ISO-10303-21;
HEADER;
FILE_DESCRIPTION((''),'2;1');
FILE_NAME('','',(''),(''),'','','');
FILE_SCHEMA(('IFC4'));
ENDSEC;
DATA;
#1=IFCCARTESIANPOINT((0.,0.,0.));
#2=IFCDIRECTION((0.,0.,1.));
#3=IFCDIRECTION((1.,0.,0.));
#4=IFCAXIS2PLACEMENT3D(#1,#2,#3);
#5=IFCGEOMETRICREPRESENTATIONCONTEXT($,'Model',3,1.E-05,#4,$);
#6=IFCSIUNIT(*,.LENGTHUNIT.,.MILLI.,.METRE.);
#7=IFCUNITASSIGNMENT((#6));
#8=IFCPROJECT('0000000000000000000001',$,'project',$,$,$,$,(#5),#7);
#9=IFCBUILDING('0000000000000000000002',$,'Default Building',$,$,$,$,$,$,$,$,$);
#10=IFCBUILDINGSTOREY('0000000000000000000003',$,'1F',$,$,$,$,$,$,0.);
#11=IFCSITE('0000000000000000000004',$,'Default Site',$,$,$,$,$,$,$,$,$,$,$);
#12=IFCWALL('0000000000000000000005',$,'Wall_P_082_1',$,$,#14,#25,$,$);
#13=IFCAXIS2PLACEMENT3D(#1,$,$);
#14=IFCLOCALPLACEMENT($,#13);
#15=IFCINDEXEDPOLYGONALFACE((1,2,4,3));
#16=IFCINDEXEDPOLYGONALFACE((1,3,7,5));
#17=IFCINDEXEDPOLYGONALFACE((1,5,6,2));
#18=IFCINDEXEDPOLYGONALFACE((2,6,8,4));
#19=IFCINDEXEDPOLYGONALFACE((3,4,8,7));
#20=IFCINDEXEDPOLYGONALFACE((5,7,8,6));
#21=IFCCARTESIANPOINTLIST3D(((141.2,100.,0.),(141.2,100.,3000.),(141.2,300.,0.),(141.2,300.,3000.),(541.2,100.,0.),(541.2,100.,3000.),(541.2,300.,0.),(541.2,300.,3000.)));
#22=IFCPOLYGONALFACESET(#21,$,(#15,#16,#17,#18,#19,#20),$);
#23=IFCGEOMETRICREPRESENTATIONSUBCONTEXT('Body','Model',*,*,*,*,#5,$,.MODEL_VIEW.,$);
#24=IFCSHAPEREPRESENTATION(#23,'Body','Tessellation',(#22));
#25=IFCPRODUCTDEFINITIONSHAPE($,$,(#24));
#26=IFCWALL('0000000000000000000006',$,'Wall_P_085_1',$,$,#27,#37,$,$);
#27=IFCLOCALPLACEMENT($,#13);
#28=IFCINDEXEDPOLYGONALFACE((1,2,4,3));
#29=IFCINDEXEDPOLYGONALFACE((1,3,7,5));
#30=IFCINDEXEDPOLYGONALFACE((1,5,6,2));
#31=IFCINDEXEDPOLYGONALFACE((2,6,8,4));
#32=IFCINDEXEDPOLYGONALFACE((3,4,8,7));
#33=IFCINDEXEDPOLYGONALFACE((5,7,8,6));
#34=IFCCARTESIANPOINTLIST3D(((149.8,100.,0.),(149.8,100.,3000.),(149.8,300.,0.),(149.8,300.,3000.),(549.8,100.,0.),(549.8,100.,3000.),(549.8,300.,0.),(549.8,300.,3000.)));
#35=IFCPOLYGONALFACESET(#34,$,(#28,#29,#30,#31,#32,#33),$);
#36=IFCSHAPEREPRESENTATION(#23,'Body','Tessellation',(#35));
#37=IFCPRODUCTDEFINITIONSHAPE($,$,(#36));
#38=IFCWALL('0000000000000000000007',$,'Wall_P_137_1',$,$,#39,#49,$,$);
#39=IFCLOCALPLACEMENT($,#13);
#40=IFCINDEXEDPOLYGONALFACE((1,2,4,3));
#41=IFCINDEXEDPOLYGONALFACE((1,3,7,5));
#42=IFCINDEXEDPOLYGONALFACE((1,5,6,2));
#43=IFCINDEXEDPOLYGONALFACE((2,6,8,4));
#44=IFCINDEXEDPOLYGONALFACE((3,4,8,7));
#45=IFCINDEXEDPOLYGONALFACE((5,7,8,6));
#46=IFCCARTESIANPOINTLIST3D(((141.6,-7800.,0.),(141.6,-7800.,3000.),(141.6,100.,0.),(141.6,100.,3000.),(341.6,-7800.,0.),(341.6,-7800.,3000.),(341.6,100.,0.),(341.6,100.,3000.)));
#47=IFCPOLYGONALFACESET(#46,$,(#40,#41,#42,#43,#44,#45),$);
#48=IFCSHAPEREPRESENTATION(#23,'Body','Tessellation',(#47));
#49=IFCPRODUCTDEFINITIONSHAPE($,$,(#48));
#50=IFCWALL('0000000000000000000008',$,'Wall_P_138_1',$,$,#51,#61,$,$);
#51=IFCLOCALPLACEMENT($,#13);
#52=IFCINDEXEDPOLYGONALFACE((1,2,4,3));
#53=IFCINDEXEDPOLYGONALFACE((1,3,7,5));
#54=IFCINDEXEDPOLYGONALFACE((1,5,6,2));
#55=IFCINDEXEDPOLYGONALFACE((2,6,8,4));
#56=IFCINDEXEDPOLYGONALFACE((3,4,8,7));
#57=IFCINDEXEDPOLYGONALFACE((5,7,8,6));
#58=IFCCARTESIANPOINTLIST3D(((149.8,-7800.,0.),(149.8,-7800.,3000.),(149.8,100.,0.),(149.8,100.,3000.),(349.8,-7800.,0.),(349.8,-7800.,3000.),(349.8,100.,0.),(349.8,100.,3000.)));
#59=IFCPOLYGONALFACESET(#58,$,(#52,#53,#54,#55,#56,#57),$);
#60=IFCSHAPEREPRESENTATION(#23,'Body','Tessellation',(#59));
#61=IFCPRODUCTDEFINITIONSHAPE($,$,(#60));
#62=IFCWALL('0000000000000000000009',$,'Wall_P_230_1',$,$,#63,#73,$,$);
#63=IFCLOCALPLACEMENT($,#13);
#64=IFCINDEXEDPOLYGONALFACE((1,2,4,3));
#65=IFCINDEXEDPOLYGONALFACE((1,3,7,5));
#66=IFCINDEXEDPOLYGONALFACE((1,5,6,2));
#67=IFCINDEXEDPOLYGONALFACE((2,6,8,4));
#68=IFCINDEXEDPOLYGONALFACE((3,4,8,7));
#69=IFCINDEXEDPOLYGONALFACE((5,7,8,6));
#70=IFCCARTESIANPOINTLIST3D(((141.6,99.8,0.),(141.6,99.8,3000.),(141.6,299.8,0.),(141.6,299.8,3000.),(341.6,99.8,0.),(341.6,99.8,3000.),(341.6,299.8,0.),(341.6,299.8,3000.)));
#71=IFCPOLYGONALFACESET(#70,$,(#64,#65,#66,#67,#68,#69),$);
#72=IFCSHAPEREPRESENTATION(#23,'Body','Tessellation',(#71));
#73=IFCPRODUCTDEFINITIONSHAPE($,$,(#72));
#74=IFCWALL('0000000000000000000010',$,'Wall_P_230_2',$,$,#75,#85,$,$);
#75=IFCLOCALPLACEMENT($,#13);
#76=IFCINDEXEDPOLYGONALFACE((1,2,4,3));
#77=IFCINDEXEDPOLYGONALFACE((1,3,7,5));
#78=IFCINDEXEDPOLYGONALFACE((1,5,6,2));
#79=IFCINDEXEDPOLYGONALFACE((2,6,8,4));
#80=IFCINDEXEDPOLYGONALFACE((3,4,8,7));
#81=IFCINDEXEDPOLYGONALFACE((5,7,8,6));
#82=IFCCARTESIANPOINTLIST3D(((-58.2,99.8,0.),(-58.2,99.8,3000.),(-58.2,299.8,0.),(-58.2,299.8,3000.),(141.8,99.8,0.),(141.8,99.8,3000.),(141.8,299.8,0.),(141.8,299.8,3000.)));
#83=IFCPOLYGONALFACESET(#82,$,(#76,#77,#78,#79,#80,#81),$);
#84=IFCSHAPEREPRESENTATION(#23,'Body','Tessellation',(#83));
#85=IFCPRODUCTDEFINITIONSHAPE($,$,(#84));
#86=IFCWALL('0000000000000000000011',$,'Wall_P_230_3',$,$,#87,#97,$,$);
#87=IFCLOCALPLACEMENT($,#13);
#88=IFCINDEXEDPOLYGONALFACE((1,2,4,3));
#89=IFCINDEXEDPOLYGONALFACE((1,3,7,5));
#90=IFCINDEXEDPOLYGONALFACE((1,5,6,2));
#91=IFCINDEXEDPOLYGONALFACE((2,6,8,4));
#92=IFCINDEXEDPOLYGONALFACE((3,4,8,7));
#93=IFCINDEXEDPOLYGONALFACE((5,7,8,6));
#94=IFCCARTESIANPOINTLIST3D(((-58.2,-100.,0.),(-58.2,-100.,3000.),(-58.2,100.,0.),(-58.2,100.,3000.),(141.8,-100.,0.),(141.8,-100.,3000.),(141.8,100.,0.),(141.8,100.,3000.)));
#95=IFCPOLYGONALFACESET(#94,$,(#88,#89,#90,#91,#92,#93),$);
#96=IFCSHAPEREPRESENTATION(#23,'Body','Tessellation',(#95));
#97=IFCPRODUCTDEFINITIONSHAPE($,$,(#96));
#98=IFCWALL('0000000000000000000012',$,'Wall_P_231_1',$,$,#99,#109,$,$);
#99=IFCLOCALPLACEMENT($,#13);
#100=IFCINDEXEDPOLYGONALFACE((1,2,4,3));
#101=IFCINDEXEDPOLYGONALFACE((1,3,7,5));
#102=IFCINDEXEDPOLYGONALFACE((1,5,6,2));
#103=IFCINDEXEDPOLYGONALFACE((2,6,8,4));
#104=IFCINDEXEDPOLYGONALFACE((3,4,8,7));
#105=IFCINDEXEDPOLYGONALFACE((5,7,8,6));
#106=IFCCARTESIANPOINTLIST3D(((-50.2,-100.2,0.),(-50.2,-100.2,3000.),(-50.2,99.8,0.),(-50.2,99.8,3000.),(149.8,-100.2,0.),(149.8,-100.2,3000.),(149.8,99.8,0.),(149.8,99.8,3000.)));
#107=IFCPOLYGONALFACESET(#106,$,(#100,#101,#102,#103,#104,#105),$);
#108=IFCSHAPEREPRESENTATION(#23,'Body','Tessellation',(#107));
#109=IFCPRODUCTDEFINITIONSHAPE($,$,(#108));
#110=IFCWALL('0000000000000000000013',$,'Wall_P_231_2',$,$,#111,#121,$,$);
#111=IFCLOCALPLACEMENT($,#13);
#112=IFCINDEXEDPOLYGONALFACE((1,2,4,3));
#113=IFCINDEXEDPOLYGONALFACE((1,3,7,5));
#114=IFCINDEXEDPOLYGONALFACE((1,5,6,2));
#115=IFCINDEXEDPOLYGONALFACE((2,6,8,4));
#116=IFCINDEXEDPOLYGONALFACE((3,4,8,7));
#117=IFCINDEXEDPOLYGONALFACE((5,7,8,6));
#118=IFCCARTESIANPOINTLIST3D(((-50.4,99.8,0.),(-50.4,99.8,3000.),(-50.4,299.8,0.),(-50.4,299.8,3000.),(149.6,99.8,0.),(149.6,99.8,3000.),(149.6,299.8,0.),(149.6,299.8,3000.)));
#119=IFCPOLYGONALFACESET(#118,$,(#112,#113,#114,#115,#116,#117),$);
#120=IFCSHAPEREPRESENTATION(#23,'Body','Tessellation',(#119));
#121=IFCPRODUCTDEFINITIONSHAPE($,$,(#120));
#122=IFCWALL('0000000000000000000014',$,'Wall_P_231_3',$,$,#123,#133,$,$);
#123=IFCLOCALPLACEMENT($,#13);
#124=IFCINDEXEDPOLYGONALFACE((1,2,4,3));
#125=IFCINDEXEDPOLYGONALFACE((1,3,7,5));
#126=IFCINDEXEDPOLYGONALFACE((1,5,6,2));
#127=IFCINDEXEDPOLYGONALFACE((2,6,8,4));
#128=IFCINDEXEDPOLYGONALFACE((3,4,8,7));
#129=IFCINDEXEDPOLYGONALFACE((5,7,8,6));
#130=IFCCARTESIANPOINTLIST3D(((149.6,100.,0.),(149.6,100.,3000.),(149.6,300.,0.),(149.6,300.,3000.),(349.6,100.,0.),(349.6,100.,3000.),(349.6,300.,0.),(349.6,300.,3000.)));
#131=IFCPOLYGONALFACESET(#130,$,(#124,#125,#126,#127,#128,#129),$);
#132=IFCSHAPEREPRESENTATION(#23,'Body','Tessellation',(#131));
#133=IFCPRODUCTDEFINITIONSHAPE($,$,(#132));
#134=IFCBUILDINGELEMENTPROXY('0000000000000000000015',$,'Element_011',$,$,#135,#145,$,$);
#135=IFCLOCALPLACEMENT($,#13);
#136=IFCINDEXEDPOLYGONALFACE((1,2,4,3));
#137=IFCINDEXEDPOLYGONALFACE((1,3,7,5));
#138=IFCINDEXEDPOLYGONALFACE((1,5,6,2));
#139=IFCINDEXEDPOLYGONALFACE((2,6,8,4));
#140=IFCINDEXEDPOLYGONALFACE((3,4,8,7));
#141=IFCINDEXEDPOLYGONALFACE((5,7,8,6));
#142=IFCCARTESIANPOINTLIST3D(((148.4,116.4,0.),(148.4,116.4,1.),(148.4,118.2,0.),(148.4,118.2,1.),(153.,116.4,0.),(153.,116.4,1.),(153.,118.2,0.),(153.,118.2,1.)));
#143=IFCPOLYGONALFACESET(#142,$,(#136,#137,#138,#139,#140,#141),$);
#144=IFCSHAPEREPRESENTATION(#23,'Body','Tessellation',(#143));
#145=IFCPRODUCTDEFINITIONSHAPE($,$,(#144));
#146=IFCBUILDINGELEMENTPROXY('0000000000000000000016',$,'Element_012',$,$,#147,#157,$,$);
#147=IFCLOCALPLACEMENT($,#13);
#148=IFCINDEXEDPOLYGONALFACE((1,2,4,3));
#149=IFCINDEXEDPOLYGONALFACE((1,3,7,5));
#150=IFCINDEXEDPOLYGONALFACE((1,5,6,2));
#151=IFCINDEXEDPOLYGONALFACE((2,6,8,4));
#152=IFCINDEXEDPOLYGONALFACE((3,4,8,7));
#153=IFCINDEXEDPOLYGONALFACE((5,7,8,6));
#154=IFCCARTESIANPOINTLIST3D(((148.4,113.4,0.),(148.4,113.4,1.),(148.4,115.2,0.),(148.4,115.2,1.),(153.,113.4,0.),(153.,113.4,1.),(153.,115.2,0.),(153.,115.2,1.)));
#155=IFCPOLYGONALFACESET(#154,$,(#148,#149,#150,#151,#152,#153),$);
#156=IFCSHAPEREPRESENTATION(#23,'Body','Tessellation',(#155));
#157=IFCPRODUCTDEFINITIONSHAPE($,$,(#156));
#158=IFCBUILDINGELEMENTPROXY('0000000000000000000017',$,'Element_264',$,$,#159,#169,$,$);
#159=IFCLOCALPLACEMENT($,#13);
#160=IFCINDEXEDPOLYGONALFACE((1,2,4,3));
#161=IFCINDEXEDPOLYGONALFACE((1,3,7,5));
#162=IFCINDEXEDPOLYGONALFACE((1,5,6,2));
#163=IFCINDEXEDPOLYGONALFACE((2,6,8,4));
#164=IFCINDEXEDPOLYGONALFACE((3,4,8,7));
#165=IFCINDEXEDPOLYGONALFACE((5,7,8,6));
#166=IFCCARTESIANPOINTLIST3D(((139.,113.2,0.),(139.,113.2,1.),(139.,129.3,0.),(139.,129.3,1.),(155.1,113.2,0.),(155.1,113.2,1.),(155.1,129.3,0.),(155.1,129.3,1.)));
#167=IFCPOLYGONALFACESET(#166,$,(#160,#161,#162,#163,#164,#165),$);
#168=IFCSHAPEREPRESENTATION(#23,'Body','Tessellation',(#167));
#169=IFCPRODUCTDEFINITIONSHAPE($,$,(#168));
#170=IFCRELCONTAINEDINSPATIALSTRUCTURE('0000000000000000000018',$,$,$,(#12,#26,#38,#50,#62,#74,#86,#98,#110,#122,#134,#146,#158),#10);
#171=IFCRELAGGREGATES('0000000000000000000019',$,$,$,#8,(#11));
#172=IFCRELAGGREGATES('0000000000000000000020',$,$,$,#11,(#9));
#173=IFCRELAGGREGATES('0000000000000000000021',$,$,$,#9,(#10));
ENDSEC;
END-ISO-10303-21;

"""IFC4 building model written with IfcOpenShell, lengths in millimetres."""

from ifc_helpers import new_model, si_unit, frame, origin, origin_with_axes, place, context, subcontext, project, spatial, indexed_curve, rectangle, outline, extrude, element, save


model = new_model("IFC4")

# Units and contexts
model_context = context("Model", 3, precision=1e-05, world=origin_with_axes())
body_context = subcontext(model_context, "Body", "Model", "MODEL_VIEW")
ifc_project = project(units=[si_unit("LENGTHUNIT", "METRE", prefix="MILLI")], contexts=[model_context])

# Site, building, storey
site = spatial("IfcSite", under=ifc_project, Name="Default Site")
building = spatial("IfcBuilding", under=site, Name="Default Building")
storey = spatial("IfcBuildingStorey", under=building, Name="1F", Elevation=0.0)

# Walls
wall_1_placement = place(None, frame((141.2, 100.0, 0.0), z_axis=(0.0, 0.0, 1.0), x_axis=(1.0, 0.0, 0.0)))
element("IfcWall", 1, at=wall_1_placement, inside=storey, Name="Wall_P_082_1", context=body_context, shape_type="SweptSolid", body=[
    extrude(outline(indexed_curve([(0.0, 0.0), (0.0, 200.0), (400.0, 200.0), (400.0, 0.0), (0.0, 0.0)], self_intersect=False)), origin_with_axes(), (0.0, 0.0, 1.0), 3000.0),
])
wall_2_placement = place(None, frame((149.8, 100.0, 0.0), z_axis=(0.0, 0.0, 1.0), x_axis=(1.0, 0.0, 0.0)))
element("IfcWall", 2, at=wall_2_placement, inside=storey, Name="Wall_P_085_1", context=body_context, shape_type="SweptSolid", body=[
    extrude(outline(indexed_curve([(0.0, 0.0), (0.0, 200.0), (400.0, 200.0), (400.0, 0.0), (0.0, 0.0)], self_intersect=False)), origin_with_axes(), (0.0, 0.0, 1.0), 3000.0),
])
for number, where, z_axis, x_axis, name in (
    (3, (141.6, 100.0, 0.0), (0.0, 0.0, 1.0), (0.0, -1.0, 0.0), "Wall_P_137_1"),
    (4, (149.8, 100.0, 0.0), (0.0, 0.0, 1.0), (0.0, -1.0, 0.0), "Wall_P_138_1"),
):
    element("IfcWall", number, at=place(None, frame(where, z_axis=z_axis, x_axis=x_axis)), inside=storey, Name=name, context=body_context, shape_type="SweptSolid", body=[
        extrude(outline(indexed_curve([(0.0, 0.0), (0.0, 200.0), (7900.0, 200.0), (7900.0, 0.0), (0.0, 0.0)], self_intersect=False)), origin_with_axes(), (0.0, 0.0, 1.0), 3000.0),
    ])
wall_3_placement = place(None, frame((141.6, 99.8, 0.0), z_axis=(0.0, 0.0, 1.0), x_axis=(1.0, 0.0, 0.0)))
element("IfcWall", 5, at=wall_3_placement, inside=storey, Name="Wall_P_230_1", context=body_context, shape_type="SweptSolid", body=[
    extrude(outline(indexed_curve([(0.0, 0.0), (0.0, 200.0), (200.0, 200.0), (200.0, 0.0), (0.0, 0.0)], self_intersect=False)), origin_with_axes(), (0.0, 0.0, 1.0), 3000.0),
])
wall_4_placement = place(None, frame((141.8, 99.8, 0.0), z_axis=(0.0, 0.0, 1.0), x_axis=(0.0, 1.0, 0.0)))
element("IfcWall", 6, at=wall_4_placement, inside=storey, Name="Wall_P_230_2", context=body_context, shape_type="SweptSolid", body=[
    extrude(outline(indexed_curve([(0.0, 0.0), (0.0, 200.0), (200.0, 200.0), (200.0, 0.0), (0.0, 0.0)], self_intersect=False)), origin_with_axes(), (0.0, 0.0, 1.0), 3000.0),
])
wall_5_placement = place(None, frame((141.8, 100.0, 0.0), z_axis=(0.0, 0.0, 1.0), x_axis=(-1.0, 0.0, 0.0)))
element("IfcWall", 7, at=wall_5_placement, inside=storey, Name="Wall_P_230_3", context=body_context, shape_type="SweptSolid", body=[
    extrude(outline(indexed_curve([(0.0, 0.0), (0.0, 200.0), (200.0, 200.0), (200.0, 0.0), (0.0, 0.0)], self_intersect=False)), origin_with_axes(), (0.0, 0.0, 1.0), 3000.0),
])
wall_6_placement = place(None, frame((149.8, 99.8, 0.0), z_axis=(0.0, 0.0, 1.0), x_axis=(-1.0, 0.0, 0.0)))
element("IfcWall", 8, at=wall_6_placement, inside=storey, Name="Wall_P_231_1", context=body_context, shape_type="SweptSolid", body=[
    extrude(outline(indexed_curve([(0.0, 0.0), (0.0, 200.0), (200.0, 200.0), (200.0, 0.0), (0.0, 0.0)], self_intersect=False)), origin_with_axes(), (0.0, 0.0, 1.0), 3000.0),
])
wall_7_placement = place(None, frame((149.6, 99.8, 0.0), z_axis=(0.0, 0.0, 1.0), x_axis=(0.0, 1.0, 0.0)))
element("IfcWall", 9, at=wall_7_placement, inside=storey, Name="Wall_P_231_2", context=body_context, shape_type="SweptSolid", body=[
    extrude(outline(indexed_curve([(0.0, 0.0), (0.0, 200.0), (200.0, 200.0), (200.0, 0.0), (0.0, 0.0)], self_intersect=False)), origin_with_axes(), (0.0, 0.0, 1.0), 3000.0),
])
wall_8_placement = place(None, frame((149.6, 100.0, 0.0), z_axis=(0.0, 0.0, 1.0), x_axis=(1.0, 0.0, 0.0)))
element("IfcWall", 10, at=wall_8_placement, inside=storey, Name="Wall_P_231_3", context=body_context, shape_type="SweptSolid", body=[
    extrude(outline(indexed_curve([(0.0, 0.0), (0.0, 200.0), (200.0, 200.0), (200.0, 0.0), (0.0, 0.0)], self_intersect=False)), origin_with_axes(), (0.0, 0.0, 1.0), 3000.0),
])

# Building element proxies
for number, where, z_axis, x_axis, name in (
    (11, (150.7, 117.3, 0.0), (0.0, 0.0, 1.0), (1.0, 0.0, 0.0), "Element_011"),
    (12, (150.7, 114.3, 0.0), (0.0, 0.0, 1.0), (1.0, 0.0, 0.0), "Element_012"),
):
    element("IfcBuildingElementProxy", number, at=place(None, frame(where, z_axis=z_axis, x_axis=x_axis)), inside=storey, Name=name, context=body_context, shape_type="SweptSolid", body=[
        extrude(rectangle(XDim=4.6, YDim=1.8), origin(), (0.0, 0.0, 1.0), 1.0),
    ])
proxy_1_placement = place(None, frame((147.1, 121.2, 0.0), z_axis=(0.0, 0.0, 1.0), x_axis=(1.0, 0.0, 0.0)))
element("IfcBuildingElementProxy", 13, at=proxy_1_placement, inside=storey, Name="Element_264", context=body_context, shape_type="SweptSolid", body=[
    extrude(rectangle(XDim=16.1, YDim=16.2), origin(), (0.0, 0.0, 1.0), 1.0),
])

save(model, "model.ifc")
